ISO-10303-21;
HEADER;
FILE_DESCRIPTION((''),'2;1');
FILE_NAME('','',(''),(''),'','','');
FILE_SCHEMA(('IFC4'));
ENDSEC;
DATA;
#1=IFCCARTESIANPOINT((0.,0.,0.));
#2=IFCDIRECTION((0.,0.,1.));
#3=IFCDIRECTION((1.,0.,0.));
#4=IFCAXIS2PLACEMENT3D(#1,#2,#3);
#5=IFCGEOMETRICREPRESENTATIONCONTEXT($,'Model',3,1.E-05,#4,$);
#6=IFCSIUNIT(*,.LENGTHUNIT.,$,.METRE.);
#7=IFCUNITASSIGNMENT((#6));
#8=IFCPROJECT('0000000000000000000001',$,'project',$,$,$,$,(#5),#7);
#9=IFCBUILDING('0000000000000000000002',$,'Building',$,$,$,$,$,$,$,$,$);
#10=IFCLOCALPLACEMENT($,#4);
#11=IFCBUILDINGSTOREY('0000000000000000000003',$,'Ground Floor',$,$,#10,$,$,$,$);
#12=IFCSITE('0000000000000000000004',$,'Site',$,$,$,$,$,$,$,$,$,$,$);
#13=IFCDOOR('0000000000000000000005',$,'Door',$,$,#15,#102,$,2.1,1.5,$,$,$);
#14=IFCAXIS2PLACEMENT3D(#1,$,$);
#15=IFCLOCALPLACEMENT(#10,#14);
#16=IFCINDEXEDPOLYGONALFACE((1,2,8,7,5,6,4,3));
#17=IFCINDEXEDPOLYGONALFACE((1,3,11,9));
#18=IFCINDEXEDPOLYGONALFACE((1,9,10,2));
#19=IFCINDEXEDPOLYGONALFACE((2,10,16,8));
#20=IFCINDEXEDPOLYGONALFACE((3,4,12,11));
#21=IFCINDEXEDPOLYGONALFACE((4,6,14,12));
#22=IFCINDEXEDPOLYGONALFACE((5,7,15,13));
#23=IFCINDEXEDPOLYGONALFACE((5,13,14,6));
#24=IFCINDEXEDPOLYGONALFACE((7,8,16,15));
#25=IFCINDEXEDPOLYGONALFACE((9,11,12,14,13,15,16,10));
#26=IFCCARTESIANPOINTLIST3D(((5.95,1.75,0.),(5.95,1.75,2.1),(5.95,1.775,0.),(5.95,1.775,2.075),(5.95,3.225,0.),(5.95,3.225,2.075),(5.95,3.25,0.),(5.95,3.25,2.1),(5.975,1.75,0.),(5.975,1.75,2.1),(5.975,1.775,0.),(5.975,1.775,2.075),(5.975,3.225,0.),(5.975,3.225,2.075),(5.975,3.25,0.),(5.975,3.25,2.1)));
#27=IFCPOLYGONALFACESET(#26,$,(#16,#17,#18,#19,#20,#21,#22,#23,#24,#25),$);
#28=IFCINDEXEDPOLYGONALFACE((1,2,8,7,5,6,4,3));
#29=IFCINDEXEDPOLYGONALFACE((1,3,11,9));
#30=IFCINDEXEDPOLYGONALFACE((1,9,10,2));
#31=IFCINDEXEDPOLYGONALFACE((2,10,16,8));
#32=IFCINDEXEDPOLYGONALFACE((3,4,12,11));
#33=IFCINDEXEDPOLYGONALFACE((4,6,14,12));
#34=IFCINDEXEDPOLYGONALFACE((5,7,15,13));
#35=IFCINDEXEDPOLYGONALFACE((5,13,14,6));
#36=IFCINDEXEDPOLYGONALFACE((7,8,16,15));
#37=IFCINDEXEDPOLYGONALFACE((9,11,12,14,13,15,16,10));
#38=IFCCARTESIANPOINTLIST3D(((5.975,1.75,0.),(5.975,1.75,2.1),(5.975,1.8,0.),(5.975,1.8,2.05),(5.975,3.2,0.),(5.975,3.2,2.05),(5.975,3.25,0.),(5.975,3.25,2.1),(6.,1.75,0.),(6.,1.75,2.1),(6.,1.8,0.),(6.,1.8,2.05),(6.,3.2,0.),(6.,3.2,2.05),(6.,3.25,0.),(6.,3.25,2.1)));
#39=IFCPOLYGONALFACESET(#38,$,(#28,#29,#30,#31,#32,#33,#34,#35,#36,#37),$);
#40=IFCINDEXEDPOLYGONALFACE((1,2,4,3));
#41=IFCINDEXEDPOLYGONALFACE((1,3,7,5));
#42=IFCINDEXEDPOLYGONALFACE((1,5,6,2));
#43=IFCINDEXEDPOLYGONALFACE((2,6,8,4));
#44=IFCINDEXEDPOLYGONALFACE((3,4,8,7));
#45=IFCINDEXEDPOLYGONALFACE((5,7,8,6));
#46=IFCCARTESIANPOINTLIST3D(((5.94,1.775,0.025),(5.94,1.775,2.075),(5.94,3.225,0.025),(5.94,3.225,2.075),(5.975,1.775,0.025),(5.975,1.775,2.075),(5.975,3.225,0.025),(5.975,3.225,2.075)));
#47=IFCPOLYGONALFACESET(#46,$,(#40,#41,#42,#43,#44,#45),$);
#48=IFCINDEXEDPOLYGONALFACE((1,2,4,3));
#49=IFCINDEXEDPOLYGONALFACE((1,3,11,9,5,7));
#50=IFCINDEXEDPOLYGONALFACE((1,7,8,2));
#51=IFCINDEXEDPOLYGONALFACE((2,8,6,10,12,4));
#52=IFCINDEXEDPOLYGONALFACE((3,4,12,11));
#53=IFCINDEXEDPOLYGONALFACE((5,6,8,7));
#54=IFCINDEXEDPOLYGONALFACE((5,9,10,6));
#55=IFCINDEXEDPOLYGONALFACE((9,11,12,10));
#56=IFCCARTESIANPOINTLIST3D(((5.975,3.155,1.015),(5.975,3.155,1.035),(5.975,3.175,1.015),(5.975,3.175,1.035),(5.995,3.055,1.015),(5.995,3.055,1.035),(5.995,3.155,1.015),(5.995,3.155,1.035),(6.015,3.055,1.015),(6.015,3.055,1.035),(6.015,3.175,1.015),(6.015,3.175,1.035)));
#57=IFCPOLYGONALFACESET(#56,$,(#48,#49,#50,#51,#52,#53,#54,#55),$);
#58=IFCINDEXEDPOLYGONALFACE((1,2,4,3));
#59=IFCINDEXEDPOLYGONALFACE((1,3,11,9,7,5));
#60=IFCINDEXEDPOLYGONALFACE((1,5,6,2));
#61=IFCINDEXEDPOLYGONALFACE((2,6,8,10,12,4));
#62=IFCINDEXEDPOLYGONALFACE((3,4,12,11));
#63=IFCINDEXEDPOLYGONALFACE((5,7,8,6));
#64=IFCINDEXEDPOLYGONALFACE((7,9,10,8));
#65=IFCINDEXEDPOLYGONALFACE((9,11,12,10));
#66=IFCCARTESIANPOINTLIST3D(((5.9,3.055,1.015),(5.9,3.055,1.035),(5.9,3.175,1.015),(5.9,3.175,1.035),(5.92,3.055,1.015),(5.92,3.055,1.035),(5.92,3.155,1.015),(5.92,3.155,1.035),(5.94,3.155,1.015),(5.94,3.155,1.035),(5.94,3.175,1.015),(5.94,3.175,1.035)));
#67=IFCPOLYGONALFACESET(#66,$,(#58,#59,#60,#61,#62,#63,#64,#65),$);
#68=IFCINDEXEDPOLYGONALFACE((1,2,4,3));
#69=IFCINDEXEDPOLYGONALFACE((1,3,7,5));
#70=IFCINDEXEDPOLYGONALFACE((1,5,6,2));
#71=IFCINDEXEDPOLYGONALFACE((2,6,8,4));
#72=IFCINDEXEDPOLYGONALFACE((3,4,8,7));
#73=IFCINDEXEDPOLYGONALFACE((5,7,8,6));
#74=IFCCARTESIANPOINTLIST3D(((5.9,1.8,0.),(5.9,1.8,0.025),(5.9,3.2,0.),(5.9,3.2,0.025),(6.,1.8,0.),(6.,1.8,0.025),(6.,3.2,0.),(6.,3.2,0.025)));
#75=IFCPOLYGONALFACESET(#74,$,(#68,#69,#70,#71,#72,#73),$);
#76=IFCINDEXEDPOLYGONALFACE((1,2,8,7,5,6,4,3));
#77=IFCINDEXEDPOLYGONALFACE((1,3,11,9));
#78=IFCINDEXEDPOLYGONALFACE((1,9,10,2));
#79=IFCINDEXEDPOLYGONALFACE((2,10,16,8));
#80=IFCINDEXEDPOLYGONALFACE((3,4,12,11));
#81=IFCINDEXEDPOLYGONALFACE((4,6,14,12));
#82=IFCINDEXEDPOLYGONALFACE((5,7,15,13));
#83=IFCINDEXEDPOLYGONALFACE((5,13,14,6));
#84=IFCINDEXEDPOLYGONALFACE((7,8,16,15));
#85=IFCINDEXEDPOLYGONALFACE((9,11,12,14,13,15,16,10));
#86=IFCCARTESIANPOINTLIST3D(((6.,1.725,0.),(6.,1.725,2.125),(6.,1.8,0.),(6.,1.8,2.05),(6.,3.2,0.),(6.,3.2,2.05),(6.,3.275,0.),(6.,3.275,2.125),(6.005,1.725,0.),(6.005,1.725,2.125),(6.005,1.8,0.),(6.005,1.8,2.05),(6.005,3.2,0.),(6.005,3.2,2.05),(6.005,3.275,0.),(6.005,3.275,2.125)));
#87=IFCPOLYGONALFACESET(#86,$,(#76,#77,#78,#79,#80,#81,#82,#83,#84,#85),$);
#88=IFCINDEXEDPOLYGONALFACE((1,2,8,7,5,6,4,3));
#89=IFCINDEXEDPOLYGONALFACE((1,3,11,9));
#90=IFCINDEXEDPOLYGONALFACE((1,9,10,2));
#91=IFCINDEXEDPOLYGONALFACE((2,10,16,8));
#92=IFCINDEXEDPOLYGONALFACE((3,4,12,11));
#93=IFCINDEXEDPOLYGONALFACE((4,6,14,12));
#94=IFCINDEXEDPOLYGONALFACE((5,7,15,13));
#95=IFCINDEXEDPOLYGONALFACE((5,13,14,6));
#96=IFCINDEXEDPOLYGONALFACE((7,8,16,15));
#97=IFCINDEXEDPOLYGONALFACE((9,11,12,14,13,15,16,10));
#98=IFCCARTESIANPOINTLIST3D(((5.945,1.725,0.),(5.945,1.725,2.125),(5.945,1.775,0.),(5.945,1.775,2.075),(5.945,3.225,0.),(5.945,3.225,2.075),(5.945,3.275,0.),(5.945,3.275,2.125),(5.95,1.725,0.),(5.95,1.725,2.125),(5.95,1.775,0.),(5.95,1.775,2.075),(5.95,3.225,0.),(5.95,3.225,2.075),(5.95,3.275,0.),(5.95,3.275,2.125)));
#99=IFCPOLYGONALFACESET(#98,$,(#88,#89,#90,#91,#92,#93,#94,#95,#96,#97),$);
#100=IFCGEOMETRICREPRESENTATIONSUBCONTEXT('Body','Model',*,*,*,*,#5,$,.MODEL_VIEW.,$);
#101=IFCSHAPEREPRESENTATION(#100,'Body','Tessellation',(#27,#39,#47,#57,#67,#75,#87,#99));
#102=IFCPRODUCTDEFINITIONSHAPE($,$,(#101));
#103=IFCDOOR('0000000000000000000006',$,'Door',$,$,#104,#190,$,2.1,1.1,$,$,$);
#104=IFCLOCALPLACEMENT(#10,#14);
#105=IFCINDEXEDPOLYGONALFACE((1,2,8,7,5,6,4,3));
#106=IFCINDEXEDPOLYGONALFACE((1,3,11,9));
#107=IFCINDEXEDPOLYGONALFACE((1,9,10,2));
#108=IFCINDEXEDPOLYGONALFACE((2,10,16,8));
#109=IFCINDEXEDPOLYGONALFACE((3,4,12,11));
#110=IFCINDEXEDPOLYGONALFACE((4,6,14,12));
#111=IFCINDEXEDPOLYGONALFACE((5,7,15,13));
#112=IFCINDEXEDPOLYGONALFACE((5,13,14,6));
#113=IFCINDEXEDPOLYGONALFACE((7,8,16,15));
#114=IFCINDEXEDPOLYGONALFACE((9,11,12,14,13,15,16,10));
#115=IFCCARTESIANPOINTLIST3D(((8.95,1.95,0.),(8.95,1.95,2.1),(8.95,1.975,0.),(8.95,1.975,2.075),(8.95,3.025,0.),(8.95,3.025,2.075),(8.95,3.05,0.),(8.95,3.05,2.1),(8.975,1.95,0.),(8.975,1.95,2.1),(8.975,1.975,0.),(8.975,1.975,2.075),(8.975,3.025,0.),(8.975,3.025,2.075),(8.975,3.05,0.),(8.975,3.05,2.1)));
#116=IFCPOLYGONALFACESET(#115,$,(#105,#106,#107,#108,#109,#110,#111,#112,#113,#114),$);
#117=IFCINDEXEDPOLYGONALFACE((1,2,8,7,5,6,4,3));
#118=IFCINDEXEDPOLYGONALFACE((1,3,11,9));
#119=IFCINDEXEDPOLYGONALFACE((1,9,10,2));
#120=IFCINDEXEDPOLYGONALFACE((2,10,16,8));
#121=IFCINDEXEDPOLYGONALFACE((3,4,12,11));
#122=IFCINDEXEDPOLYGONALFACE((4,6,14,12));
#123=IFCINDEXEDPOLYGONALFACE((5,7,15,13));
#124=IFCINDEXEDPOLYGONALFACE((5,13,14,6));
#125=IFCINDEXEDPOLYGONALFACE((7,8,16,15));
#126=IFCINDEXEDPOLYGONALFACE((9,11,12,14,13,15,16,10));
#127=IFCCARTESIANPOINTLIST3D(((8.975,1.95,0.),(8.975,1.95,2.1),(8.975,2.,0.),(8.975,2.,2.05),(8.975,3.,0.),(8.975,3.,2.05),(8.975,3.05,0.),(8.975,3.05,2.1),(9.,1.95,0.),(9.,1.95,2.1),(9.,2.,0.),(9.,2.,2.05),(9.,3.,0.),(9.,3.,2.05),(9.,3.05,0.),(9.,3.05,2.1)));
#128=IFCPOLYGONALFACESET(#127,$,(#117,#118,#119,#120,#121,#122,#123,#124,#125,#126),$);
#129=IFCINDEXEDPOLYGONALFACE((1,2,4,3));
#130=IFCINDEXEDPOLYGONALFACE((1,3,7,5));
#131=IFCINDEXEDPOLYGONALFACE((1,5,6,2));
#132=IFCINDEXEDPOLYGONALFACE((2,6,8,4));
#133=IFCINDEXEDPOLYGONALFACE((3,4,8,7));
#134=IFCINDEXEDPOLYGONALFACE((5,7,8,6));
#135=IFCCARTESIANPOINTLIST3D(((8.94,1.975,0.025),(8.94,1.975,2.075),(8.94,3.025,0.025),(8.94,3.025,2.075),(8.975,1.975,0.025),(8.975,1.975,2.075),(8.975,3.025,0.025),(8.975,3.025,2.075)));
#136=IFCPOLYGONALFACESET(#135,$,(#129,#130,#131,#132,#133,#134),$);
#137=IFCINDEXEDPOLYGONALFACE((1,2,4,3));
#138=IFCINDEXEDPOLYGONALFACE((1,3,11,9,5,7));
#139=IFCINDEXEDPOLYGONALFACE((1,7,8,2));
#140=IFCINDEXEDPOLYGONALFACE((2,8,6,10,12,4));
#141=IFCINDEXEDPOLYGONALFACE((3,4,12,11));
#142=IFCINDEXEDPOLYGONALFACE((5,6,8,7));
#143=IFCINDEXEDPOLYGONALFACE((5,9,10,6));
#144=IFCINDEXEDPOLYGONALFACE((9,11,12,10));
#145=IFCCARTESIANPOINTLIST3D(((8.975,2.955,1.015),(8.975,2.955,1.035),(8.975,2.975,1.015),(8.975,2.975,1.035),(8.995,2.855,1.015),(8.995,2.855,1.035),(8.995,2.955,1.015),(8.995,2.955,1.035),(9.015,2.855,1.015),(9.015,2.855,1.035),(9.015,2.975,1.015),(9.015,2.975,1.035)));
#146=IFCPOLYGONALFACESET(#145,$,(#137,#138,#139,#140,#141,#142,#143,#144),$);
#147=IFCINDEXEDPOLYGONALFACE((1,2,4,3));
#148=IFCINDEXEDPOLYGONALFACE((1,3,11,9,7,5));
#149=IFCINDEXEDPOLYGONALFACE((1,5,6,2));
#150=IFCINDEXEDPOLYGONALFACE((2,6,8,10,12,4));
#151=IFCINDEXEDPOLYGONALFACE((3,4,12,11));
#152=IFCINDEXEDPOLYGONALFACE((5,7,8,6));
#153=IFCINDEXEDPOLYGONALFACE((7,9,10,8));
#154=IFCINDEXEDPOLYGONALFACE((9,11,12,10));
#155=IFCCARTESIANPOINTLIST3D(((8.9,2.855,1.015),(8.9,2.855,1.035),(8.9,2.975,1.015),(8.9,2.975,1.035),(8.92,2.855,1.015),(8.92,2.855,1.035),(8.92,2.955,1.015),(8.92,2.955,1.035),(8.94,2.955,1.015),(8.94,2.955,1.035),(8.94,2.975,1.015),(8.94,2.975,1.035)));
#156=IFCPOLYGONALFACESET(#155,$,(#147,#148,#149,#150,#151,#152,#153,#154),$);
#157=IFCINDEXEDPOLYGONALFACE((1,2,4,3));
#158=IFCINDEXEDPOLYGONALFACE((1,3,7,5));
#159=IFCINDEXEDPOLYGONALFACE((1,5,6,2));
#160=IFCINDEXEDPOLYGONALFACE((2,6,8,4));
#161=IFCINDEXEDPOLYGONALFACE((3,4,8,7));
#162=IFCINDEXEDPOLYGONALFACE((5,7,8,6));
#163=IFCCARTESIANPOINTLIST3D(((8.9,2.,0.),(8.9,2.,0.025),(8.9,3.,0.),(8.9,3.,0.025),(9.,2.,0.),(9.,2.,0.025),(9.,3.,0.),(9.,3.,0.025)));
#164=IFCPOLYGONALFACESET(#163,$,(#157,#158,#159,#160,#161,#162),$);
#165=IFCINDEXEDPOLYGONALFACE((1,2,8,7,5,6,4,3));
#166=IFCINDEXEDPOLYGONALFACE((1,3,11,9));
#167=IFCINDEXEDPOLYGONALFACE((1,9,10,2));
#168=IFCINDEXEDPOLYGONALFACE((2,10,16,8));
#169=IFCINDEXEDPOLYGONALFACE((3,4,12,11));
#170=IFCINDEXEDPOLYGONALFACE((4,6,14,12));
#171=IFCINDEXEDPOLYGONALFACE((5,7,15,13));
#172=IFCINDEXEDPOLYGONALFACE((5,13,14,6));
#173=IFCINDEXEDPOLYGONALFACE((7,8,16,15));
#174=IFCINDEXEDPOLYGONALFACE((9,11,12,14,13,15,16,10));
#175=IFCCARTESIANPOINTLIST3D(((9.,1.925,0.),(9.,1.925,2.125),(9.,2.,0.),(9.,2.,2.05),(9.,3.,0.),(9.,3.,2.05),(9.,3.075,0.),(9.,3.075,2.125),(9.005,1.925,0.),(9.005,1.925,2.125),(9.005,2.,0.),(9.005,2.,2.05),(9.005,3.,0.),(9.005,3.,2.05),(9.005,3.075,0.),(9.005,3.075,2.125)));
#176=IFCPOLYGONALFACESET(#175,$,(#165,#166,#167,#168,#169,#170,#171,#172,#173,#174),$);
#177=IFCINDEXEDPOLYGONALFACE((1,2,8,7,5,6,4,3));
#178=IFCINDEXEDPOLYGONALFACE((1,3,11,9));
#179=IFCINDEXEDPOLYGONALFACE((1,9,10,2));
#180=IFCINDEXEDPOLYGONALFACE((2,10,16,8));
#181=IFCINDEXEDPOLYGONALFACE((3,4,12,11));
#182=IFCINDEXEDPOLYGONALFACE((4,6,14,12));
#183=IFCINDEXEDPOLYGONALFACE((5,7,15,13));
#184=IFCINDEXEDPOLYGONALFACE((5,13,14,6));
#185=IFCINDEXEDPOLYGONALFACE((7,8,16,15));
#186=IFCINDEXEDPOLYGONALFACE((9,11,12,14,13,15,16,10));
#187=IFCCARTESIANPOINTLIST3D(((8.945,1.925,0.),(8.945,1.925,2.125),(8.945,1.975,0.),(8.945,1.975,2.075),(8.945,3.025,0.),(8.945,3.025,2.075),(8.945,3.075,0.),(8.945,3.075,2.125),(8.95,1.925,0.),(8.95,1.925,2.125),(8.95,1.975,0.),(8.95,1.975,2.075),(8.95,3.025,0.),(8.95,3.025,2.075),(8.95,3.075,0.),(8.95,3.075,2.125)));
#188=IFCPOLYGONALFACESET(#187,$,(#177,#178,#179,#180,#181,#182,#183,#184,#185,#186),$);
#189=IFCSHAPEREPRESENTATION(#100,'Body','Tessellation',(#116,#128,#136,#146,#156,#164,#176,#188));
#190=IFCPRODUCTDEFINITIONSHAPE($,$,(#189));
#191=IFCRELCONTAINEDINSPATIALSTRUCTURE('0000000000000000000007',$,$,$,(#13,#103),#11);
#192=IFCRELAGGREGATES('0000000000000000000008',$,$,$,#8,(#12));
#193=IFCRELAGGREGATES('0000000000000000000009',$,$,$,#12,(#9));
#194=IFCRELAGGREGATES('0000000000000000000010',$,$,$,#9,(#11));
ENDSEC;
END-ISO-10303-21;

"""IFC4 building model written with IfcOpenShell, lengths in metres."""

from ifc_helpers import new_model, si_unit, frame, origin_with_axes, place, context, subcontext, project, spatial, line, indexed_curve, outline, extrude, element, save


model = new_model("IFC4")

# Units and contexts
model_context = context("Model", 3, precision=1e-05, world=origin_with_axes())
body_context = subcontext(model_context, "Body", "Model", "MODEL_VIEW")
ifc_project = project(units=[si_unit("LENGTHUNIT", "METRE")], contexts=[model_context])

# Site, building, storey
site = spatial("IfcSite", under=ifc_project, Name="Site")
building = spatial("IfcBuilding", under=site, Name="Building")
storey_placement = place(None, origin_with_axes())
storey = spatial("IfcBuildingStorey", under=building, at=storey_placement, Name="Ground Floor")

# Doors
door_1_placement = place(storey_placement, frame((6.0, 1.75, 0.0), z_axis=(0.0, 0.0, 1.0), x_axis=(0.0, 1.0, 0.0)))
element("IfcDoor", 1, at=door_1_placement, inside=storey, Name="Door", OverallHeight=2.1, OverallWidth=1.5, context=body_context, shape_type="SweptSolid", body=[
    extrude(outline(indexed_curve([(0.0, 0.0), (0.0, 2.1), (1.5, 2.1), (1.5, 0.0), (1.475, 0.0), (1.475, 2.075), (0.025, 2.075), (0.025, 0.0)], segments=[line(1, 2, 3, 4, 5, 6, 7, 8, 1)])), frame((0.0, 0.025, 0.0), z_axis=(0.0, -1.0, 0.0), x_axis=(1.0, 0.0, 0.0)), (0.0, 0.0, -1.0), 0.025),
    extrude(outline(indexed_curve([(0.0, 0.0), (0.0, 2.1), (1.5, 2.1), (1.5, 0.0), (1.45, 0.0), (1.45, 2.05), (0.05, 2.05), (0.05, 0.0)], segments=[line(1, 2, 3, 4, 5, 6, 7, 8, 1)])), frame((0.0, 0.0, 0.0), z_axis=(0.0, -1.0, 0.0), x_axis=(1.0, 0.0, 0.0)), (0.0, 0.0, -1.0), 0.025),
    extrude(outline(indexed_curve([(0.0, 0.0), (1.45, 0.0), (1.45, 0.035), (0.0, 0.035)], segments=[line(1, 2, 3, 4, 1)])), frame((0.025, 0.025, 0.025), z_axis=(0.0, 0.0, 1.0), x_axis=(1.0, 0.0, 0.0)), (0.0, 0.0, 1.0), 2.05),
    extrude(outline(indexed_curve([(0.0, 0.0), (0.0, -0.04), (-0.12, -0.04), (-0.12, -0.02), (-0.02, -0.02), (-0.02, 0.0)], segments=[line(1, 2, 3, 4, 5, 6, 1)])), frame((1.425, 0.025, 1.015), z_axis=(0.0, 0.0, 1.0), x_axis=(1.0, 0.0, 0.0)), (0.0, 0.0, 1.0), 0.02),
    extrude(outline(indexed_curve([(0.0, 0.0), (0.0, 0.04), (-0.12, 0.04), (-0.12, 0.02), (-0.02, 0.02), (-0.02, 0.0)], segments=[line(1, 2, 3, 4, 5, 6, 1)])), frame((1.425, 0.06, 1.015), z_axis=(0.0, 0.0, 1.0), x_axis=(1.0, 0.0, 0.0)), (0.0, 0.0, 1.0), 0.02),
    extrude(outline(indexed_curve([(0.0, 0.0), (1.4, 0.0), (1.4, 0.1), (0.0, 0.1)], segments=[line(1, 2, 3, 4, 1)])), frame((0.05, 0.0, 0.0), z_axis=(0.0, 0.0, 1.0), x_axis=(1.0, 0.0, 0.0)), (0.0, 0.0, 1.0), 0.025),
    extrude(outline(indexed_curve([(0.0, 0.0), (0.0, 2.125), (1.55, 2.125), (1.55, 0.0), (1.475, 0.0), (1.475, 2.05), (0.075, 2.05), (0.075, 0.0)], segments=[line(1, 2, 3, 4, 5, 6, 7, 8, 1)])), frame((-0.025, -0.005, 0.0), z_axis=(0.0, -1.0, 0.0), x_axis=(1.0, 0.0, 0.0)), (0.0, 0.0, -1.0), 0.005),
    extrude(outline(indexed_curve([(0.0, 0.0), (0.0, 2.125), (1.55, 2.125), (1.55, 0.0), (1.5, 0.0), (1.5, 2.075), (0.05, 2.075), (0.05, 0.0)], segments=[line(1, 2, 3, 4, 5, 6, 7, 8, 1)])), frame((-0.025, 0.05, 0.0), z_axis=(0.0, -1.0, 0.0), x_axis=(1.0, 0.0, 0.0)), (0.0, 0.0, -1.0), 0.005),
])
door_2_placement = place(storey_placement, frame((9.0, 1.95, 0.0), z_axis=(0.0, 0.0, 1.0), x_axis=(0.0, 1.0, 0.0)))
element("IfcDoor", 2, at=door_2_placement, inside=storey, Name="Door", OverallHeight=2.1, OverallWidth=1.1, context=body_context, shape_type="SweptSolid", body=[
    extrude(outline(indexed_curve([(0.0, 0.0), (0.0, 2.1), (1.1, 2.1), (1.1, 0.0), (1.075, 0.0), (1.075, 2.075), (0.025, 2.075), (0.025, 0.0)], segments=[line(1, 2, 3, 4, 5, 6, 7, 8, 1)])), frame((0.0, 0.025, 0.0), z_axis=(0.0, -1.0, 0.0), x_axis=(1.0, 0.0, 0.0)), (0.0, 0.0, -1.0), 0.025),
    extrude(outline(indexed_curve([(0.0, 0.0), (0.0, 2.1), (1.1, 2.1), (1.1, 0.0), (1.05, 0.0), (1.05, 2.05), (0.05, 2.05), (0.05, 0.0)], segments=[line(1, 2, 3, 4, 5, 6, 7, 8, 1)])), frame((0.0, 0.0, 0.0), z_axis=(0.0, -1.0, 0.0), x_axis=(1.0, 0.0, 0.0)), (0.0, 0.0, -1.0), 0.025),
    extrude(outline(indexed_curve([(0.0, 0.0), (1.05, 0.0), (1.05, 0.035), (0.0, 0.035)], segments=[line(1, 2, 3, 4, 1)])), frame((0.025, 0.025, 0.025), z_axis=(0.0, 0.0, 1.0), x_axis=(1.0, 0.0, 0.0)), (0.0, 0.0, 1.0), 2.05),
    extrude(outline(indexed_curve([(0.0, 0.0), (0.0, -0.04), (-0.12, -0.04), (-0.12, -0.02), (-0.02, -0.02), (-0.02, 0.0)], segments=[line(1, 2, 3, 4, 5, 6, 1)])), frame((1.025, 0.025, 1.015), z_axis=(0.0, 0.0, 1.0), x_axis=(1.0, 0.0, 0.0)), (0.0, 0.0, 1.0), 0.02),
    extrude(outline(indexed_curve([(0.0, 0.0), (0.0, 0.04), (-0.12, 0.04), (-0.12, 0.02), (-0.02, 0.02), (-0.02, 0.0)], segments=[line(1, 2, 3, 4, 5, 6, 1)])), frame((1.025, 0.06, 1.015), z_axis=(0.0, 0.0, 1.0), x_axis=(1.0, 0.0, 0.0)), (0.0, 0.0, 1.0), 0.02),
    extrude(outline(indexed_curve([(0.0, 0.0), (1.0, 0.0), (1.0, 0.1), (0.0, 0.1)], segments=[line(1, 2, 3, 4, 1)])), frame((0.05, 0.0, 0.0), z_axis=(0.0, 0.0, 1.0), x_axis=(1.0, 0.0, 0.0)), (0.0, 0.0, 1.0), 0.025),
    extrude(outline(indexed_curve([(0.0, 0.0), (0.0, 2.125), (1.15, 2.125), (1.15, 0.0), (1.075, 0.0), (1.075, 2.05), (0.075, 2.05), (0.075, 0.0)], segments=[line(1, 2, 3, 4, 5, 6, 7, 8, 1)])), frame((-0.025, -0.005, 0.0), z_axis=(0.0, -1.0, 0.0), x_axis=(1.0, 0.0, 0.0)), (0.0, 0.0, -1.0), 0.005),
    extrude(outline(indexed_curve([(0.0, 0.0), (0.0, 2.125), (1.15, 2.125), (1.15, 0.0), (1.1, 0.0), (1.1, 2.075), (0.05, 2.075), (0.05, 0.0)], segments=[line(1, 2, 3, 4, 5, 6, 7, 8, 1)])), frame((-0.025, 0.05, 0.0), z_axis=(0.0, -1.0, 0.0), x_axis=(1.0, 0.0, 0.0)), (0.0, 0.0, -1.0), 0.005),
])

save(model, "model.ifc")
